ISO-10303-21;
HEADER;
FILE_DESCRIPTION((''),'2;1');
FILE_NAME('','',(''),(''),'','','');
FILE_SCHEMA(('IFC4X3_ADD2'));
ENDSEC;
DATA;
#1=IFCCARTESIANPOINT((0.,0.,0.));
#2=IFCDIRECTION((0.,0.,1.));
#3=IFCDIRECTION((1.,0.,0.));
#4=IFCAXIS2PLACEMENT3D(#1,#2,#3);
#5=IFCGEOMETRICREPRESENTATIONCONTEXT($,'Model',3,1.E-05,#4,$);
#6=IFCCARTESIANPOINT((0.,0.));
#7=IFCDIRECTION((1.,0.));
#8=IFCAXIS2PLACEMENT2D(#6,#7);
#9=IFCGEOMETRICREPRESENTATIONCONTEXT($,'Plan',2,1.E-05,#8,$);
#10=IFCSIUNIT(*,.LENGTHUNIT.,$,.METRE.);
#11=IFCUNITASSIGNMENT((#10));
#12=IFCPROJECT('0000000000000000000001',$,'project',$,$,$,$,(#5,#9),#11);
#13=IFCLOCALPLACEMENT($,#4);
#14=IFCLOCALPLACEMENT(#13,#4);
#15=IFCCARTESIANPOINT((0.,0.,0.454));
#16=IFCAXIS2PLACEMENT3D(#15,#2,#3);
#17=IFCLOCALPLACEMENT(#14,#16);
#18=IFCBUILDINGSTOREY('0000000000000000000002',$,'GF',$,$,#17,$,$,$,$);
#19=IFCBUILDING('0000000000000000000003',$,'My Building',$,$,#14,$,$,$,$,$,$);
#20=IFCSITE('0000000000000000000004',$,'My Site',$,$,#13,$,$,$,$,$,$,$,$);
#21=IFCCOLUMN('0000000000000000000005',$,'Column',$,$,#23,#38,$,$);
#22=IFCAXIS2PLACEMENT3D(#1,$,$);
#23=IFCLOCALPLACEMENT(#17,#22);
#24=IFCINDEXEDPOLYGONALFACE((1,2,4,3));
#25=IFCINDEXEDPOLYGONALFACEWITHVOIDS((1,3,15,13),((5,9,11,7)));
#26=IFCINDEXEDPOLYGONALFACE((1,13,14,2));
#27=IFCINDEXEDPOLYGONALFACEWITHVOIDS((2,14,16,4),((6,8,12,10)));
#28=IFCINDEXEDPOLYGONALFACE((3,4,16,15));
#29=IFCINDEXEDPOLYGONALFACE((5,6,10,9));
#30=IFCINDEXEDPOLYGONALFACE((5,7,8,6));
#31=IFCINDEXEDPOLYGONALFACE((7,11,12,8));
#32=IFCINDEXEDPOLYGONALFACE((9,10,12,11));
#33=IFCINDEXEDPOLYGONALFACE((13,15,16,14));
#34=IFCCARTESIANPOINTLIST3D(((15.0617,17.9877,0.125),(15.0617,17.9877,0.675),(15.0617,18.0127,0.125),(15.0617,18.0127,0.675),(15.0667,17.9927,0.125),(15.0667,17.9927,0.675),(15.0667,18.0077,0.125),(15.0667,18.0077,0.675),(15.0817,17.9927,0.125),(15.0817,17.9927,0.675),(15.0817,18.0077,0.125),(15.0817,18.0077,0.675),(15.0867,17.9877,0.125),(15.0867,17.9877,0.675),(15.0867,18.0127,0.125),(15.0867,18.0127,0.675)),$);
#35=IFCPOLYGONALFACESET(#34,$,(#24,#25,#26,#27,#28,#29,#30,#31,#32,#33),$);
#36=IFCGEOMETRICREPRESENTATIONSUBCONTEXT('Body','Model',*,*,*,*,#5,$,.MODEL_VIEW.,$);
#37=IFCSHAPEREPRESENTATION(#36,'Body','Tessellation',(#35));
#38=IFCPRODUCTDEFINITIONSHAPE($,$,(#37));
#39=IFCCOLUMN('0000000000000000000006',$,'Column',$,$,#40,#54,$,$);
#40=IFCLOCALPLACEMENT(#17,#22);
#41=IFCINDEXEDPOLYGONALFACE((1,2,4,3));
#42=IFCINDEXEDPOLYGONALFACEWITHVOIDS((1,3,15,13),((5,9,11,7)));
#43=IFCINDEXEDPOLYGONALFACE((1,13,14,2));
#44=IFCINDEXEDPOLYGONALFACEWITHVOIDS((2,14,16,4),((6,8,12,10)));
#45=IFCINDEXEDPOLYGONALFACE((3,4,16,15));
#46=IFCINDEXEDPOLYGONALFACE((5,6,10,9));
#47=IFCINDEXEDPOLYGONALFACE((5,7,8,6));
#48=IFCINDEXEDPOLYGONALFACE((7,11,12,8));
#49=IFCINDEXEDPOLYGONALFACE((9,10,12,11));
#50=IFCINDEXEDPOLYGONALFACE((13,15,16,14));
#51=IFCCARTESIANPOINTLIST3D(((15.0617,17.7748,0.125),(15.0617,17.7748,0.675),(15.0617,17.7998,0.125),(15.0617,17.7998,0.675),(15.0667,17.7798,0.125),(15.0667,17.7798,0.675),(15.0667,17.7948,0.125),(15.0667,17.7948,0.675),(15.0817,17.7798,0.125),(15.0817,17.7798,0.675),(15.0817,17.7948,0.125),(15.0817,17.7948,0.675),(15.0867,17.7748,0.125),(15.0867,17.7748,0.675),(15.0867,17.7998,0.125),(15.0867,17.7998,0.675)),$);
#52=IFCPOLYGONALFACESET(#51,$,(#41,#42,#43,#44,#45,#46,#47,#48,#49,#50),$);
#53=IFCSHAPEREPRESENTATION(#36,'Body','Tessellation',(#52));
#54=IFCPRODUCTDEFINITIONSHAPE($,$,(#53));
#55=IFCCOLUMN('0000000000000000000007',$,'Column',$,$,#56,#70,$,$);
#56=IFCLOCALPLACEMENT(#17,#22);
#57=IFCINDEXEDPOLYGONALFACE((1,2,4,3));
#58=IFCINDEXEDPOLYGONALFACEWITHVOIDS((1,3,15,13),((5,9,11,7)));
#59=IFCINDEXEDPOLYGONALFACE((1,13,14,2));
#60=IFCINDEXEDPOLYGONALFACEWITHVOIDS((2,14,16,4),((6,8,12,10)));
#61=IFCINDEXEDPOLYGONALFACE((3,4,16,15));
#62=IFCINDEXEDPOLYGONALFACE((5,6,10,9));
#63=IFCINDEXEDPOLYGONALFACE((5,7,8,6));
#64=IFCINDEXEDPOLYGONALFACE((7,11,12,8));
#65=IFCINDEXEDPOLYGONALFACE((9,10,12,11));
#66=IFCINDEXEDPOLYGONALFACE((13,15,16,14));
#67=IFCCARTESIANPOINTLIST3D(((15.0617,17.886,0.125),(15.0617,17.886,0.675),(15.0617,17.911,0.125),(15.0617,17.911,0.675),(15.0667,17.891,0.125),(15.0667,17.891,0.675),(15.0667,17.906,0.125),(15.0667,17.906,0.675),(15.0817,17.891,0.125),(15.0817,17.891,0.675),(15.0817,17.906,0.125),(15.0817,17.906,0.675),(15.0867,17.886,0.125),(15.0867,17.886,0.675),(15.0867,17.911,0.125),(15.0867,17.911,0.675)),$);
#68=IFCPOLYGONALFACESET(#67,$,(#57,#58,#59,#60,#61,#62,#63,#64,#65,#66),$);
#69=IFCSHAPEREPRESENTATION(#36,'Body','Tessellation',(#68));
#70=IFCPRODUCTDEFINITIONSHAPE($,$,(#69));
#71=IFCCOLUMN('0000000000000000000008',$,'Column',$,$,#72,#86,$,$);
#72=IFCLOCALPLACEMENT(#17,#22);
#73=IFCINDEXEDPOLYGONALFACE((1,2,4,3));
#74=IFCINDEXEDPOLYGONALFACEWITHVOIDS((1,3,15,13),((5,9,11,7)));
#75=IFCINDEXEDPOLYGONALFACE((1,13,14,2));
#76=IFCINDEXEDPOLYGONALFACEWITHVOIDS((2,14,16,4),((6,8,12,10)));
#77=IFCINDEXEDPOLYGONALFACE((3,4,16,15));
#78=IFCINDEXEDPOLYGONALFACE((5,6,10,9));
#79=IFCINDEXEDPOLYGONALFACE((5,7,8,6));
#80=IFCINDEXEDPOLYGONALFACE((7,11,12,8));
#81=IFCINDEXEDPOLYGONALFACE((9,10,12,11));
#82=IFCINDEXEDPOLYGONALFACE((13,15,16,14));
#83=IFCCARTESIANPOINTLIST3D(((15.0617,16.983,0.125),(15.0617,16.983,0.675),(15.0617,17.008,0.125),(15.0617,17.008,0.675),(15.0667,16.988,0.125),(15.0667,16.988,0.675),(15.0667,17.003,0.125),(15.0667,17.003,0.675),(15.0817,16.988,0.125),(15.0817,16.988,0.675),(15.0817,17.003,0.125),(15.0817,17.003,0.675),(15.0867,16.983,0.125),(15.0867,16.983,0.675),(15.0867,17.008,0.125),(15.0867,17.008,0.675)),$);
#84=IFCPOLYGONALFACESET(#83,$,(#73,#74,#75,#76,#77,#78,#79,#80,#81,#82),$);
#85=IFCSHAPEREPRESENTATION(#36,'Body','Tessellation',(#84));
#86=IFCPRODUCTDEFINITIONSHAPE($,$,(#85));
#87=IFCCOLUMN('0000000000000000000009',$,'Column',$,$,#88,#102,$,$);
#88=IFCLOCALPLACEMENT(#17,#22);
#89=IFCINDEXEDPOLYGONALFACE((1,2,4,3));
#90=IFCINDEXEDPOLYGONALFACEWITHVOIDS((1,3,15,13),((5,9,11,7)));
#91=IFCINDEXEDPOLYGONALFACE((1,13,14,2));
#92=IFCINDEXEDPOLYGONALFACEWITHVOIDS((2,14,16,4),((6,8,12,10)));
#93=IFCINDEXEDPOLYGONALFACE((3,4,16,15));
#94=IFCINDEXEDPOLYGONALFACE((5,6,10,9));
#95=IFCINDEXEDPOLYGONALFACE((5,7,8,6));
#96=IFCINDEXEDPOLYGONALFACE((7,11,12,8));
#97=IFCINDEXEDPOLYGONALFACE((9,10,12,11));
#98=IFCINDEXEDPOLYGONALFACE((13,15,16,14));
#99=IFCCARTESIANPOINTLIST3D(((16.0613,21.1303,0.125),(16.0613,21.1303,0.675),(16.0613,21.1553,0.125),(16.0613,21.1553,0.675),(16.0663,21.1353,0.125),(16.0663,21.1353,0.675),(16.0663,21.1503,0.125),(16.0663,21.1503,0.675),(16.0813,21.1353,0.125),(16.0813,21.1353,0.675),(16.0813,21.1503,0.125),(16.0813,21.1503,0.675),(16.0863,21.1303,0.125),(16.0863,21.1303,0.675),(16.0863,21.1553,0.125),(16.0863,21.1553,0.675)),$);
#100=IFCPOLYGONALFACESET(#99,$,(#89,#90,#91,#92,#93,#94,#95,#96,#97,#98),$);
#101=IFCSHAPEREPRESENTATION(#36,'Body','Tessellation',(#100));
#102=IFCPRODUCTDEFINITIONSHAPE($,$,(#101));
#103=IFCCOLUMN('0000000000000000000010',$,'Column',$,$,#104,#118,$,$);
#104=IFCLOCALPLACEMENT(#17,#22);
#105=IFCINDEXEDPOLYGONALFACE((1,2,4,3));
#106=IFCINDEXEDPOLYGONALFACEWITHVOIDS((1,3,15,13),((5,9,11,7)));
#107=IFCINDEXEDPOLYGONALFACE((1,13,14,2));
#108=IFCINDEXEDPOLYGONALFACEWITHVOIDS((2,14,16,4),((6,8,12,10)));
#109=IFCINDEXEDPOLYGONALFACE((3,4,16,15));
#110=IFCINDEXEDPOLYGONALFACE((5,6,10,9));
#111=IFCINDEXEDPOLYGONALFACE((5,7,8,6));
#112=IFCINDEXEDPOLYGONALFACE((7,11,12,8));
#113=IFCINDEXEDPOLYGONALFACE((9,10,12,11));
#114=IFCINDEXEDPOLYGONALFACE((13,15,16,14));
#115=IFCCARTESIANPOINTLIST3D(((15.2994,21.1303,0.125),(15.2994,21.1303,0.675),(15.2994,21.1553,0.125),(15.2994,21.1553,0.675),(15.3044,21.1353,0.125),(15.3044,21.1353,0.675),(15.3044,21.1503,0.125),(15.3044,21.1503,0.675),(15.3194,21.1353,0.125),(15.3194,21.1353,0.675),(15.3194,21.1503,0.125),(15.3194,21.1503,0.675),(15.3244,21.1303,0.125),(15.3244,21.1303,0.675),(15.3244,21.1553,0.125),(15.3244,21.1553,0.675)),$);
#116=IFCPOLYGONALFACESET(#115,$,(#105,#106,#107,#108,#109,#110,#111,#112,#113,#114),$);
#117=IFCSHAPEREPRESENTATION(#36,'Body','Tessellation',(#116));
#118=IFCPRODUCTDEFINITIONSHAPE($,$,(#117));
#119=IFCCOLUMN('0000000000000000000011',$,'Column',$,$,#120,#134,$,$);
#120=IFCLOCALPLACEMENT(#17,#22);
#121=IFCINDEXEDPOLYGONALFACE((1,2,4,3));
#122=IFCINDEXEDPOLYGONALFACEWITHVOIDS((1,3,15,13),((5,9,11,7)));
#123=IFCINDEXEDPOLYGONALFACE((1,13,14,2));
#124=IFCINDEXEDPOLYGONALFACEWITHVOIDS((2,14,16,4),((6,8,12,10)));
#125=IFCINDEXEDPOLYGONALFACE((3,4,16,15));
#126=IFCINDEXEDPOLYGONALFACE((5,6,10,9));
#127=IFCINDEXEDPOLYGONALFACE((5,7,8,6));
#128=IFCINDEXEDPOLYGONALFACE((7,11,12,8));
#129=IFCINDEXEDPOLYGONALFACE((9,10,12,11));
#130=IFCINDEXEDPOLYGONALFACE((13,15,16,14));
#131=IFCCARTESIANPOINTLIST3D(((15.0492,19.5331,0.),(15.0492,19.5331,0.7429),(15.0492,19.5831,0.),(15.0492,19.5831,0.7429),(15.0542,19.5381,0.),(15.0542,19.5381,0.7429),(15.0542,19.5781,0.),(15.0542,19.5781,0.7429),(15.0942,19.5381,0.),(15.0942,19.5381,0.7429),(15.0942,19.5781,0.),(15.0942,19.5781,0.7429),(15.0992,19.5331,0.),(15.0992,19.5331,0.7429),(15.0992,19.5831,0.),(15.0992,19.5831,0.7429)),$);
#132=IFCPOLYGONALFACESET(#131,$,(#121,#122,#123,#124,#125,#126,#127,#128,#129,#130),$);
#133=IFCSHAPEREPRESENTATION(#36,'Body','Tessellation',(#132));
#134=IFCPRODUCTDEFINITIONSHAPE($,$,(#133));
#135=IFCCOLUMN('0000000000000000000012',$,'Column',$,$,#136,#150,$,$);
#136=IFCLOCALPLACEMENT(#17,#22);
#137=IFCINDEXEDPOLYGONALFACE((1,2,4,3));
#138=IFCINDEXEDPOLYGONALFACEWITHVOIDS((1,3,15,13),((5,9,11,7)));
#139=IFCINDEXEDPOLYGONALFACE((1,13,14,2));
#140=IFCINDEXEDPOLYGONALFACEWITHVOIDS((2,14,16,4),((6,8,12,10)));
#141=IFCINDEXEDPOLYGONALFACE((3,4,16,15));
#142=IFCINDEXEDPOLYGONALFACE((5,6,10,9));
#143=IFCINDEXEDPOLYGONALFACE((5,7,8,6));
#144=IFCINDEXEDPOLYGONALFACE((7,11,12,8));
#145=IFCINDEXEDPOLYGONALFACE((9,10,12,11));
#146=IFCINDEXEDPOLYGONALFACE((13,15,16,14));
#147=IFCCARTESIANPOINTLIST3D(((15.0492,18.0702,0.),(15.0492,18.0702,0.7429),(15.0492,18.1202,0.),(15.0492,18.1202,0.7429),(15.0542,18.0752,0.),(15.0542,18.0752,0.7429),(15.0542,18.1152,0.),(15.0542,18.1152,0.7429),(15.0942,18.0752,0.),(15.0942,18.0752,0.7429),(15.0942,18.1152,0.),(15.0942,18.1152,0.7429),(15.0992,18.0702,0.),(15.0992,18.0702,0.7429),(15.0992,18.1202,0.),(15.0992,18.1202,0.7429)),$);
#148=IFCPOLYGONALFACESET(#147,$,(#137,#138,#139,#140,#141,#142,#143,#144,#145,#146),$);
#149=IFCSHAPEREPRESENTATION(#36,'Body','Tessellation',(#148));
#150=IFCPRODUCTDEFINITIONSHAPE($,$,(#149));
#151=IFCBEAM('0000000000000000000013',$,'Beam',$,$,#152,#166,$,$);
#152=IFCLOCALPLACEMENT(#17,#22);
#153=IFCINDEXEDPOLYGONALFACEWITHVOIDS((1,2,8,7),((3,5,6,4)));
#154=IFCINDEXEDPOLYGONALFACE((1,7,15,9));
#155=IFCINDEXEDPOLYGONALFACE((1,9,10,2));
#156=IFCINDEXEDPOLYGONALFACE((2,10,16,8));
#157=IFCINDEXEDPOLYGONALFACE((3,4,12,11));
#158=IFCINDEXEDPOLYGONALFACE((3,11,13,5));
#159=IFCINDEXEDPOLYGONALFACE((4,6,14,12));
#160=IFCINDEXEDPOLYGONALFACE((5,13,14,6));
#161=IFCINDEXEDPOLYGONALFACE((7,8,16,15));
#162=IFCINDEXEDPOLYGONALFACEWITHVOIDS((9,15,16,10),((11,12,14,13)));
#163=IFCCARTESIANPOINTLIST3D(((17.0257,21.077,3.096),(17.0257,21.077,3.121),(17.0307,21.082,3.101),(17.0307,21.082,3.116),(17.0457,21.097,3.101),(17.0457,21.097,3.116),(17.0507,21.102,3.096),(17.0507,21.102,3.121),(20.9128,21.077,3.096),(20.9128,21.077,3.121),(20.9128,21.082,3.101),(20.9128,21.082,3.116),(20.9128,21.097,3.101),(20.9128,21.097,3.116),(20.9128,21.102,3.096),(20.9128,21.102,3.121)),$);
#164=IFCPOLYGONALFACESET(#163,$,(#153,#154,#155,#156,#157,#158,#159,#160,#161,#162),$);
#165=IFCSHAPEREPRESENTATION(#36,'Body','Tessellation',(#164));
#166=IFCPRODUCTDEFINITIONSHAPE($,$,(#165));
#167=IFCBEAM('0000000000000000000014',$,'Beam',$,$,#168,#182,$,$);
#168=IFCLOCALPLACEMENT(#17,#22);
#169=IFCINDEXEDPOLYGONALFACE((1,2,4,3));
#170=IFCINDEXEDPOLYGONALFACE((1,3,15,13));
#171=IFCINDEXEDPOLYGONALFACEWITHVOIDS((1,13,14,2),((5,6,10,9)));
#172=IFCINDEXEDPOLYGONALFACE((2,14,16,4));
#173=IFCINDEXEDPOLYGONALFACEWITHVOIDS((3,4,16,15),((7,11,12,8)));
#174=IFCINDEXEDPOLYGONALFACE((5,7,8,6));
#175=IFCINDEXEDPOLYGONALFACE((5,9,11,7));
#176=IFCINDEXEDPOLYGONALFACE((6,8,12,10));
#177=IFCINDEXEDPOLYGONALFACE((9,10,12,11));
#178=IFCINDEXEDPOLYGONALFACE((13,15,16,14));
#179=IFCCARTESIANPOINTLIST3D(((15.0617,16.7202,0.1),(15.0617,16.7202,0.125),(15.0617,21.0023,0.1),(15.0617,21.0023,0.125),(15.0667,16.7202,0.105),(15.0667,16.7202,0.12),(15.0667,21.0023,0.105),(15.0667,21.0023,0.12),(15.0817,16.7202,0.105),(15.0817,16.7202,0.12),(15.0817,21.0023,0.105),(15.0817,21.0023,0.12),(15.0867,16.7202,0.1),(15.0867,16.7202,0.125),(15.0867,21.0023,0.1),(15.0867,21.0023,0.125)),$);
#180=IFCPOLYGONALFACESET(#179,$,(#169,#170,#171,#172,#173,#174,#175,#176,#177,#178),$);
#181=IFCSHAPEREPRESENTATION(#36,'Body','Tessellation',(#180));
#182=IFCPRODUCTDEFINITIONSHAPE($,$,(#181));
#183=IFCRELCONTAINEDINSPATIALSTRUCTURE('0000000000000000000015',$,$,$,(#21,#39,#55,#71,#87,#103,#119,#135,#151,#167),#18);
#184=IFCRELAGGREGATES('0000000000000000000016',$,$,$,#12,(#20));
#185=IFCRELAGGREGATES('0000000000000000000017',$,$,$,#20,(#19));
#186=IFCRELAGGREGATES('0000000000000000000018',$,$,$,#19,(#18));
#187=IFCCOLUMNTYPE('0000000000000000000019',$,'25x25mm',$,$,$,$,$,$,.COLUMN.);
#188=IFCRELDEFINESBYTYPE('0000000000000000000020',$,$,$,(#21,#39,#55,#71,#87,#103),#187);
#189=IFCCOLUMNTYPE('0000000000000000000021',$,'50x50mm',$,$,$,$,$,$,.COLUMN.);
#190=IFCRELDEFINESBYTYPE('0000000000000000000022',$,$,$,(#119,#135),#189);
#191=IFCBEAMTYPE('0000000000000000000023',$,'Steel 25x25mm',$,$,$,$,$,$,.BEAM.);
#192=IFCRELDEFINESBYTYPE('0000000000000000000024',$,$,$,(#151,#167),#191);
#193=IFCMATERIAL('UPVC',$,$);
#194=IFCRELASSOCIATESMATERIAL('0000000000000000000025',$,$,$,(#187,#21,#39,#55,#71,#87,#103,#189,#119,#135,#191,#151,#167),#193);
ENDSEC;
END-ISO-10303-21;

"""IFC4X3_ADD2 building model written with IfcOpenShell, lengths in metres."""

from ifc_helpers import new_model, si_unit, frame, origin_with_axes, origin_2d_with_axis, place, context, subcontext, project, spatial, hollow_rectangle, extrude, clip, halfspace, material, material_profile, profile_set, profile_usage, type_object, element, save


model = new_model("IFC4X3_ADD2")

# Units and contexts
model_context = context("Model", 3, precision=1e-05, world=origin_with_axes())
plan_context = context("Plan", 2, precision=1e-05, world=origin_2d_with_axis())
body_context = subcontext(model_context, "Body", "Model", "MODEL_VIEW")
ifc_project = project(units=[si_unit("LENGTHUNIT", "METRE")], contexts=[model_context, plan_context])

# Site, building, storey
site_placement = place(None, origin_with_axes())
site = spatial("IfcSite", under=ifc_project, at=site_placement, Name="My Site")
building_placement = place(site_placement, origin_with_axes())
building = spatial("IfcBuilding", under=site, at=building_placement, Name="My Building")
storey_placement = place(building_placement, frame((0.0, 0.0, 0.454), z_axis=(0.0, 0.0, 1.0), x_axis=(1.0, 0.0, 0.0)))
storey = spatial("IfcBuildingStorey", under=building, at=storey_placement, Name="GF")

# Columns
ifc_material_1 = material(Name="UPVC")
ifc_material_profile_1 = material_profile(ifc_material_1, hollow_rectangle(XDim=0.025, YDim=0.025, WallThickness=0.005))
ifc_profile_set_1 = profile_set([ifc_material_profile_1])
column_type_1 = type_object("IfcColumnType", Name="25x25mm", PredefinedType="COLUMN", material=ifc_profile_set_1)
ifc_profile_usage_1 = profile_usage(ifc_profile_set_1)
column_1_placement = place(storey_placement, frame((15.0742, 18.0002, 0.125), z_axis=(0.0, 0.0, 1.0), x_axis=(0.0, -1.0, 0.0)))
element("IfcColumn", 1, at=column_1_placement, inside=storey, type_object=column_type_1, material=ifc_profile_usage_1, Name="Column", context=body_context, shape_type="SweptSolid", body=[
    extrude(hollow_rectangle(XDim=0.025, YDim=0.025, WallThickness=0.005), origin_with_axes(), (0.0, 0.0, 1.0), 0.55),
])
ifc_profile_usage_2 = profile_usage(ifc_profile_set_1)
column_2_placement = place(storey_placement, frame((15.0742, 17.7873, 0.125), z_axis=(0.0, 0.0, 1.0), x_axis=(0.0, -1.0, 0.0)))
element("IfcColumn", 2, at=column_2_placement, inside=storey, type_object=column_type_1, material=ifc_profile_usage_2, Name="Column", context=body_context, shape_type="SweptSolid", body=[
    extrude(hollow_rectangle(XDim=0.025, YDim=0.025, WallThickness=0.005), origin_with_axes(), (0.0, 0.0, 1.0), 0.55),
])
ifc_profile_usage_3 = profile_usage(ifc_profile_set_1)
column_3_placement = place(storey_placement, frame((15.0742, 17.8985, 0.125), z_axis=(0.0, 0.0, 1.0), x_axis=(0.0, -1.0, 0.0)))
element("IfcColumn", 3, at=column_3_placement, inside=storey, type_object=column_type_1, material=ifc_profile_usage_3, Name="Column", context=body_context, shape_type="SweptSolid", body=[
    extrude(hollow_rectangle(XDim=0.025, YDim=0.025, WallThickness=0.005), origin_with_axes(), (0.0, 0.0, 1.0), 0.55),
])
ifc_profile_usage_4 = profile_usage(ifc_profile_set_1)
column_4_placement = place(storey_placement, frame((15.0742, 16.9955, 0.125), z_axis=(0.0, 0.0, 1.0), x_axis=(0.0, -1.0, 0.0)))
element("IfcColumn", 4, at=column_4_placement, inside=storey, type_object=column_type_1, material=ifc_profile_usage_4, Name="Column", context=body_context, shape_type="SweptSolid", body=[
    extrude(hollow_rectangle(XDim=0.025, YDim=0.025, WallThickness=0.005), origin_with_axes(), (0.0, 0.0, 1.0), 0.55),
])
ifc_profile_usage_5 = profile_usage(ifc_profile_set_1)
column_5_placement = place(storey_placement, frame((16.0738, 21.1428, 0.125), z_axis=(0.0, 0.0, 1.0), x_axis=(0.0, -1.0, 0.0)))
element("IfcColumn", 5, at=column_5_placement, inside=storey, type_object=column_type_1, material=ifc_profile_usage_5, Name="Column", context=body_context, shape_type="SweptSolid", body=[
    extrude(hollow_rectangle(XDim=0.025, YDim=0.025, WallThickness=0.005), origin_with_axes(), (0.0, 0.0, 1.0), 0.55),
])
ifc_profile_usage_6 = profile_usage(ifc_profile_set_1)
column_6_placement = place(storey_placement, frame((15.3119, 21.1428, 0.125), z_axis=(0.0, 0.0, 1.0), x_axis=(0.0, -1.0, 0.0)))
element("IfcColumn", 6, at=column_6_placement, inside=storey, type_object=column_type_1, material=ifc_profile_usage_6, Name="Column", context=body_context, shape_type="SweptSolid", body=[
    extrude(hollow_rectangle(XDim=0.025, YDim=0.025, WallThickness=0.005), origin_with_axes(), (0.0, 0.0, 1.0), 0.55),
])
ifc_material_profile_2 = material_profile(ifc_material_1, hollow_rectangle(XDim=0.05, YDim=0.05, WallThickness=0.005))
ifc_profile_set_2 = profile_set([ifc_material_profile_2])
ifc_profile_usage_7 = profile_usage(ifc_profile_set_2)
column_type_2 = type_object("IfcColumnType", Name="50x50mm", PredefinedType="COLUMN", material=ifc_profile_set_2)
column_7_placement = place(storey_placement, frame((15.0742, 19.5581, 0.0), z_axis=(0.0, 0.0, 1.0), x_axis=(0.0, -1.0, 0.0)))
element("IfcColumn", 7, at=column_7_placement, inside=storey, type_object=column_type_2, material=ifc_profile_usage_7, Name="Column", context=body_context, shape_type="SweptSolid", body=[
    extrude(hollow_rectangle(XDim=0.05, YDim=0.05, WallThickness=0.005), origin_with_axes(), (0.0, 0.0, 1.0), 0.7429),
])
ifc_profile_usage_8 = profile_usage(ifc_profile_set_2)
column_8_placement = place(storey_placement, frame((15.0742, 18.0952, 0.0), z_axis=(0.0, 0.0, 1.0), x_axis=(0.0, -1.0, 0.0)))
element("IfcColumn", 8, at=column_8_placement, inside=storey, type_object=column_type_2, material=ifc_profile_usage_8, Name="Column", context=body_context, shape_type="SweptSolid", body=[
    extrude(hollow_rectangle(XDim=0.05, YDim=0.05, WallThickness=0.005), origin_with_axes(), (0.0, 0.0, 1.0), 0.7429),
])

# Beams
ifc_material_profile_3 = material_profile(ifc_material_1, hollow_rectangle(XDim=0.025, YDim=0.025, WallThickness=0.005))
ifc_profile_set_3 = profile_set([ifc_material_profile_3])
ifc_profile_usage_9 = profile_usage(ifc_profile_set_3)
beam_type_1 = type_object("IfcBeamType", Name="Steel 25x25mm", PredefinedType="BEAM", material=ifc_profile_set_3)
beam_1_placement = place(storey_placement, frame((17.0257, 21.0895, 3.1085), z_axis=(1.0, 0.0, 0.0), x_axis=(0.0, 1.0, 0.0)))
element("IfcBeam", 9, at=beam_1_placement, inside=storey, type_object=beam_type_1, material=ifc_profile_usage_9, Name="Beam", context=body_context, shape_type="Clipping", body=[
    clip(extrude(hollow_rectangle(XDim=0.025, YDim=0.025, WallThickness=0.005), origin_with_axes(), (0.0, 0.0, 1.0), 3.8871), halfspace(frame((-0.0125, -3.5625, 0.0), z_axis=(0.707134, 0.0, -0.70708), x_axis=(0.0, -1.0, 0.0)), False)),
])
ifc_profile_usage_10 = profile_usage(ifc_profile_set_3)
beam_2_placement = place(storey_placement, frame((15.0742, 21.0023, 0.1125), z_axis=(0.0, -1.0, 0.0), x_axis=(1.0, 0.0, 0.0)))
element("IfcBeam", 10, at=beam_2_placement, inside=storey, type_object=beam_type_1, material=ifc_profile_usage_10, Name="Beam", context=body_context, shape_type="SweptSolid", body=[
    extrude(hollow_rectangle(XDim=0.025, YDim=0.025, WallThickness=0.005), origin_with_axes(), (0.0, 0.0, 1.0), 4.2821),
])

save(model, "model.ifc")
